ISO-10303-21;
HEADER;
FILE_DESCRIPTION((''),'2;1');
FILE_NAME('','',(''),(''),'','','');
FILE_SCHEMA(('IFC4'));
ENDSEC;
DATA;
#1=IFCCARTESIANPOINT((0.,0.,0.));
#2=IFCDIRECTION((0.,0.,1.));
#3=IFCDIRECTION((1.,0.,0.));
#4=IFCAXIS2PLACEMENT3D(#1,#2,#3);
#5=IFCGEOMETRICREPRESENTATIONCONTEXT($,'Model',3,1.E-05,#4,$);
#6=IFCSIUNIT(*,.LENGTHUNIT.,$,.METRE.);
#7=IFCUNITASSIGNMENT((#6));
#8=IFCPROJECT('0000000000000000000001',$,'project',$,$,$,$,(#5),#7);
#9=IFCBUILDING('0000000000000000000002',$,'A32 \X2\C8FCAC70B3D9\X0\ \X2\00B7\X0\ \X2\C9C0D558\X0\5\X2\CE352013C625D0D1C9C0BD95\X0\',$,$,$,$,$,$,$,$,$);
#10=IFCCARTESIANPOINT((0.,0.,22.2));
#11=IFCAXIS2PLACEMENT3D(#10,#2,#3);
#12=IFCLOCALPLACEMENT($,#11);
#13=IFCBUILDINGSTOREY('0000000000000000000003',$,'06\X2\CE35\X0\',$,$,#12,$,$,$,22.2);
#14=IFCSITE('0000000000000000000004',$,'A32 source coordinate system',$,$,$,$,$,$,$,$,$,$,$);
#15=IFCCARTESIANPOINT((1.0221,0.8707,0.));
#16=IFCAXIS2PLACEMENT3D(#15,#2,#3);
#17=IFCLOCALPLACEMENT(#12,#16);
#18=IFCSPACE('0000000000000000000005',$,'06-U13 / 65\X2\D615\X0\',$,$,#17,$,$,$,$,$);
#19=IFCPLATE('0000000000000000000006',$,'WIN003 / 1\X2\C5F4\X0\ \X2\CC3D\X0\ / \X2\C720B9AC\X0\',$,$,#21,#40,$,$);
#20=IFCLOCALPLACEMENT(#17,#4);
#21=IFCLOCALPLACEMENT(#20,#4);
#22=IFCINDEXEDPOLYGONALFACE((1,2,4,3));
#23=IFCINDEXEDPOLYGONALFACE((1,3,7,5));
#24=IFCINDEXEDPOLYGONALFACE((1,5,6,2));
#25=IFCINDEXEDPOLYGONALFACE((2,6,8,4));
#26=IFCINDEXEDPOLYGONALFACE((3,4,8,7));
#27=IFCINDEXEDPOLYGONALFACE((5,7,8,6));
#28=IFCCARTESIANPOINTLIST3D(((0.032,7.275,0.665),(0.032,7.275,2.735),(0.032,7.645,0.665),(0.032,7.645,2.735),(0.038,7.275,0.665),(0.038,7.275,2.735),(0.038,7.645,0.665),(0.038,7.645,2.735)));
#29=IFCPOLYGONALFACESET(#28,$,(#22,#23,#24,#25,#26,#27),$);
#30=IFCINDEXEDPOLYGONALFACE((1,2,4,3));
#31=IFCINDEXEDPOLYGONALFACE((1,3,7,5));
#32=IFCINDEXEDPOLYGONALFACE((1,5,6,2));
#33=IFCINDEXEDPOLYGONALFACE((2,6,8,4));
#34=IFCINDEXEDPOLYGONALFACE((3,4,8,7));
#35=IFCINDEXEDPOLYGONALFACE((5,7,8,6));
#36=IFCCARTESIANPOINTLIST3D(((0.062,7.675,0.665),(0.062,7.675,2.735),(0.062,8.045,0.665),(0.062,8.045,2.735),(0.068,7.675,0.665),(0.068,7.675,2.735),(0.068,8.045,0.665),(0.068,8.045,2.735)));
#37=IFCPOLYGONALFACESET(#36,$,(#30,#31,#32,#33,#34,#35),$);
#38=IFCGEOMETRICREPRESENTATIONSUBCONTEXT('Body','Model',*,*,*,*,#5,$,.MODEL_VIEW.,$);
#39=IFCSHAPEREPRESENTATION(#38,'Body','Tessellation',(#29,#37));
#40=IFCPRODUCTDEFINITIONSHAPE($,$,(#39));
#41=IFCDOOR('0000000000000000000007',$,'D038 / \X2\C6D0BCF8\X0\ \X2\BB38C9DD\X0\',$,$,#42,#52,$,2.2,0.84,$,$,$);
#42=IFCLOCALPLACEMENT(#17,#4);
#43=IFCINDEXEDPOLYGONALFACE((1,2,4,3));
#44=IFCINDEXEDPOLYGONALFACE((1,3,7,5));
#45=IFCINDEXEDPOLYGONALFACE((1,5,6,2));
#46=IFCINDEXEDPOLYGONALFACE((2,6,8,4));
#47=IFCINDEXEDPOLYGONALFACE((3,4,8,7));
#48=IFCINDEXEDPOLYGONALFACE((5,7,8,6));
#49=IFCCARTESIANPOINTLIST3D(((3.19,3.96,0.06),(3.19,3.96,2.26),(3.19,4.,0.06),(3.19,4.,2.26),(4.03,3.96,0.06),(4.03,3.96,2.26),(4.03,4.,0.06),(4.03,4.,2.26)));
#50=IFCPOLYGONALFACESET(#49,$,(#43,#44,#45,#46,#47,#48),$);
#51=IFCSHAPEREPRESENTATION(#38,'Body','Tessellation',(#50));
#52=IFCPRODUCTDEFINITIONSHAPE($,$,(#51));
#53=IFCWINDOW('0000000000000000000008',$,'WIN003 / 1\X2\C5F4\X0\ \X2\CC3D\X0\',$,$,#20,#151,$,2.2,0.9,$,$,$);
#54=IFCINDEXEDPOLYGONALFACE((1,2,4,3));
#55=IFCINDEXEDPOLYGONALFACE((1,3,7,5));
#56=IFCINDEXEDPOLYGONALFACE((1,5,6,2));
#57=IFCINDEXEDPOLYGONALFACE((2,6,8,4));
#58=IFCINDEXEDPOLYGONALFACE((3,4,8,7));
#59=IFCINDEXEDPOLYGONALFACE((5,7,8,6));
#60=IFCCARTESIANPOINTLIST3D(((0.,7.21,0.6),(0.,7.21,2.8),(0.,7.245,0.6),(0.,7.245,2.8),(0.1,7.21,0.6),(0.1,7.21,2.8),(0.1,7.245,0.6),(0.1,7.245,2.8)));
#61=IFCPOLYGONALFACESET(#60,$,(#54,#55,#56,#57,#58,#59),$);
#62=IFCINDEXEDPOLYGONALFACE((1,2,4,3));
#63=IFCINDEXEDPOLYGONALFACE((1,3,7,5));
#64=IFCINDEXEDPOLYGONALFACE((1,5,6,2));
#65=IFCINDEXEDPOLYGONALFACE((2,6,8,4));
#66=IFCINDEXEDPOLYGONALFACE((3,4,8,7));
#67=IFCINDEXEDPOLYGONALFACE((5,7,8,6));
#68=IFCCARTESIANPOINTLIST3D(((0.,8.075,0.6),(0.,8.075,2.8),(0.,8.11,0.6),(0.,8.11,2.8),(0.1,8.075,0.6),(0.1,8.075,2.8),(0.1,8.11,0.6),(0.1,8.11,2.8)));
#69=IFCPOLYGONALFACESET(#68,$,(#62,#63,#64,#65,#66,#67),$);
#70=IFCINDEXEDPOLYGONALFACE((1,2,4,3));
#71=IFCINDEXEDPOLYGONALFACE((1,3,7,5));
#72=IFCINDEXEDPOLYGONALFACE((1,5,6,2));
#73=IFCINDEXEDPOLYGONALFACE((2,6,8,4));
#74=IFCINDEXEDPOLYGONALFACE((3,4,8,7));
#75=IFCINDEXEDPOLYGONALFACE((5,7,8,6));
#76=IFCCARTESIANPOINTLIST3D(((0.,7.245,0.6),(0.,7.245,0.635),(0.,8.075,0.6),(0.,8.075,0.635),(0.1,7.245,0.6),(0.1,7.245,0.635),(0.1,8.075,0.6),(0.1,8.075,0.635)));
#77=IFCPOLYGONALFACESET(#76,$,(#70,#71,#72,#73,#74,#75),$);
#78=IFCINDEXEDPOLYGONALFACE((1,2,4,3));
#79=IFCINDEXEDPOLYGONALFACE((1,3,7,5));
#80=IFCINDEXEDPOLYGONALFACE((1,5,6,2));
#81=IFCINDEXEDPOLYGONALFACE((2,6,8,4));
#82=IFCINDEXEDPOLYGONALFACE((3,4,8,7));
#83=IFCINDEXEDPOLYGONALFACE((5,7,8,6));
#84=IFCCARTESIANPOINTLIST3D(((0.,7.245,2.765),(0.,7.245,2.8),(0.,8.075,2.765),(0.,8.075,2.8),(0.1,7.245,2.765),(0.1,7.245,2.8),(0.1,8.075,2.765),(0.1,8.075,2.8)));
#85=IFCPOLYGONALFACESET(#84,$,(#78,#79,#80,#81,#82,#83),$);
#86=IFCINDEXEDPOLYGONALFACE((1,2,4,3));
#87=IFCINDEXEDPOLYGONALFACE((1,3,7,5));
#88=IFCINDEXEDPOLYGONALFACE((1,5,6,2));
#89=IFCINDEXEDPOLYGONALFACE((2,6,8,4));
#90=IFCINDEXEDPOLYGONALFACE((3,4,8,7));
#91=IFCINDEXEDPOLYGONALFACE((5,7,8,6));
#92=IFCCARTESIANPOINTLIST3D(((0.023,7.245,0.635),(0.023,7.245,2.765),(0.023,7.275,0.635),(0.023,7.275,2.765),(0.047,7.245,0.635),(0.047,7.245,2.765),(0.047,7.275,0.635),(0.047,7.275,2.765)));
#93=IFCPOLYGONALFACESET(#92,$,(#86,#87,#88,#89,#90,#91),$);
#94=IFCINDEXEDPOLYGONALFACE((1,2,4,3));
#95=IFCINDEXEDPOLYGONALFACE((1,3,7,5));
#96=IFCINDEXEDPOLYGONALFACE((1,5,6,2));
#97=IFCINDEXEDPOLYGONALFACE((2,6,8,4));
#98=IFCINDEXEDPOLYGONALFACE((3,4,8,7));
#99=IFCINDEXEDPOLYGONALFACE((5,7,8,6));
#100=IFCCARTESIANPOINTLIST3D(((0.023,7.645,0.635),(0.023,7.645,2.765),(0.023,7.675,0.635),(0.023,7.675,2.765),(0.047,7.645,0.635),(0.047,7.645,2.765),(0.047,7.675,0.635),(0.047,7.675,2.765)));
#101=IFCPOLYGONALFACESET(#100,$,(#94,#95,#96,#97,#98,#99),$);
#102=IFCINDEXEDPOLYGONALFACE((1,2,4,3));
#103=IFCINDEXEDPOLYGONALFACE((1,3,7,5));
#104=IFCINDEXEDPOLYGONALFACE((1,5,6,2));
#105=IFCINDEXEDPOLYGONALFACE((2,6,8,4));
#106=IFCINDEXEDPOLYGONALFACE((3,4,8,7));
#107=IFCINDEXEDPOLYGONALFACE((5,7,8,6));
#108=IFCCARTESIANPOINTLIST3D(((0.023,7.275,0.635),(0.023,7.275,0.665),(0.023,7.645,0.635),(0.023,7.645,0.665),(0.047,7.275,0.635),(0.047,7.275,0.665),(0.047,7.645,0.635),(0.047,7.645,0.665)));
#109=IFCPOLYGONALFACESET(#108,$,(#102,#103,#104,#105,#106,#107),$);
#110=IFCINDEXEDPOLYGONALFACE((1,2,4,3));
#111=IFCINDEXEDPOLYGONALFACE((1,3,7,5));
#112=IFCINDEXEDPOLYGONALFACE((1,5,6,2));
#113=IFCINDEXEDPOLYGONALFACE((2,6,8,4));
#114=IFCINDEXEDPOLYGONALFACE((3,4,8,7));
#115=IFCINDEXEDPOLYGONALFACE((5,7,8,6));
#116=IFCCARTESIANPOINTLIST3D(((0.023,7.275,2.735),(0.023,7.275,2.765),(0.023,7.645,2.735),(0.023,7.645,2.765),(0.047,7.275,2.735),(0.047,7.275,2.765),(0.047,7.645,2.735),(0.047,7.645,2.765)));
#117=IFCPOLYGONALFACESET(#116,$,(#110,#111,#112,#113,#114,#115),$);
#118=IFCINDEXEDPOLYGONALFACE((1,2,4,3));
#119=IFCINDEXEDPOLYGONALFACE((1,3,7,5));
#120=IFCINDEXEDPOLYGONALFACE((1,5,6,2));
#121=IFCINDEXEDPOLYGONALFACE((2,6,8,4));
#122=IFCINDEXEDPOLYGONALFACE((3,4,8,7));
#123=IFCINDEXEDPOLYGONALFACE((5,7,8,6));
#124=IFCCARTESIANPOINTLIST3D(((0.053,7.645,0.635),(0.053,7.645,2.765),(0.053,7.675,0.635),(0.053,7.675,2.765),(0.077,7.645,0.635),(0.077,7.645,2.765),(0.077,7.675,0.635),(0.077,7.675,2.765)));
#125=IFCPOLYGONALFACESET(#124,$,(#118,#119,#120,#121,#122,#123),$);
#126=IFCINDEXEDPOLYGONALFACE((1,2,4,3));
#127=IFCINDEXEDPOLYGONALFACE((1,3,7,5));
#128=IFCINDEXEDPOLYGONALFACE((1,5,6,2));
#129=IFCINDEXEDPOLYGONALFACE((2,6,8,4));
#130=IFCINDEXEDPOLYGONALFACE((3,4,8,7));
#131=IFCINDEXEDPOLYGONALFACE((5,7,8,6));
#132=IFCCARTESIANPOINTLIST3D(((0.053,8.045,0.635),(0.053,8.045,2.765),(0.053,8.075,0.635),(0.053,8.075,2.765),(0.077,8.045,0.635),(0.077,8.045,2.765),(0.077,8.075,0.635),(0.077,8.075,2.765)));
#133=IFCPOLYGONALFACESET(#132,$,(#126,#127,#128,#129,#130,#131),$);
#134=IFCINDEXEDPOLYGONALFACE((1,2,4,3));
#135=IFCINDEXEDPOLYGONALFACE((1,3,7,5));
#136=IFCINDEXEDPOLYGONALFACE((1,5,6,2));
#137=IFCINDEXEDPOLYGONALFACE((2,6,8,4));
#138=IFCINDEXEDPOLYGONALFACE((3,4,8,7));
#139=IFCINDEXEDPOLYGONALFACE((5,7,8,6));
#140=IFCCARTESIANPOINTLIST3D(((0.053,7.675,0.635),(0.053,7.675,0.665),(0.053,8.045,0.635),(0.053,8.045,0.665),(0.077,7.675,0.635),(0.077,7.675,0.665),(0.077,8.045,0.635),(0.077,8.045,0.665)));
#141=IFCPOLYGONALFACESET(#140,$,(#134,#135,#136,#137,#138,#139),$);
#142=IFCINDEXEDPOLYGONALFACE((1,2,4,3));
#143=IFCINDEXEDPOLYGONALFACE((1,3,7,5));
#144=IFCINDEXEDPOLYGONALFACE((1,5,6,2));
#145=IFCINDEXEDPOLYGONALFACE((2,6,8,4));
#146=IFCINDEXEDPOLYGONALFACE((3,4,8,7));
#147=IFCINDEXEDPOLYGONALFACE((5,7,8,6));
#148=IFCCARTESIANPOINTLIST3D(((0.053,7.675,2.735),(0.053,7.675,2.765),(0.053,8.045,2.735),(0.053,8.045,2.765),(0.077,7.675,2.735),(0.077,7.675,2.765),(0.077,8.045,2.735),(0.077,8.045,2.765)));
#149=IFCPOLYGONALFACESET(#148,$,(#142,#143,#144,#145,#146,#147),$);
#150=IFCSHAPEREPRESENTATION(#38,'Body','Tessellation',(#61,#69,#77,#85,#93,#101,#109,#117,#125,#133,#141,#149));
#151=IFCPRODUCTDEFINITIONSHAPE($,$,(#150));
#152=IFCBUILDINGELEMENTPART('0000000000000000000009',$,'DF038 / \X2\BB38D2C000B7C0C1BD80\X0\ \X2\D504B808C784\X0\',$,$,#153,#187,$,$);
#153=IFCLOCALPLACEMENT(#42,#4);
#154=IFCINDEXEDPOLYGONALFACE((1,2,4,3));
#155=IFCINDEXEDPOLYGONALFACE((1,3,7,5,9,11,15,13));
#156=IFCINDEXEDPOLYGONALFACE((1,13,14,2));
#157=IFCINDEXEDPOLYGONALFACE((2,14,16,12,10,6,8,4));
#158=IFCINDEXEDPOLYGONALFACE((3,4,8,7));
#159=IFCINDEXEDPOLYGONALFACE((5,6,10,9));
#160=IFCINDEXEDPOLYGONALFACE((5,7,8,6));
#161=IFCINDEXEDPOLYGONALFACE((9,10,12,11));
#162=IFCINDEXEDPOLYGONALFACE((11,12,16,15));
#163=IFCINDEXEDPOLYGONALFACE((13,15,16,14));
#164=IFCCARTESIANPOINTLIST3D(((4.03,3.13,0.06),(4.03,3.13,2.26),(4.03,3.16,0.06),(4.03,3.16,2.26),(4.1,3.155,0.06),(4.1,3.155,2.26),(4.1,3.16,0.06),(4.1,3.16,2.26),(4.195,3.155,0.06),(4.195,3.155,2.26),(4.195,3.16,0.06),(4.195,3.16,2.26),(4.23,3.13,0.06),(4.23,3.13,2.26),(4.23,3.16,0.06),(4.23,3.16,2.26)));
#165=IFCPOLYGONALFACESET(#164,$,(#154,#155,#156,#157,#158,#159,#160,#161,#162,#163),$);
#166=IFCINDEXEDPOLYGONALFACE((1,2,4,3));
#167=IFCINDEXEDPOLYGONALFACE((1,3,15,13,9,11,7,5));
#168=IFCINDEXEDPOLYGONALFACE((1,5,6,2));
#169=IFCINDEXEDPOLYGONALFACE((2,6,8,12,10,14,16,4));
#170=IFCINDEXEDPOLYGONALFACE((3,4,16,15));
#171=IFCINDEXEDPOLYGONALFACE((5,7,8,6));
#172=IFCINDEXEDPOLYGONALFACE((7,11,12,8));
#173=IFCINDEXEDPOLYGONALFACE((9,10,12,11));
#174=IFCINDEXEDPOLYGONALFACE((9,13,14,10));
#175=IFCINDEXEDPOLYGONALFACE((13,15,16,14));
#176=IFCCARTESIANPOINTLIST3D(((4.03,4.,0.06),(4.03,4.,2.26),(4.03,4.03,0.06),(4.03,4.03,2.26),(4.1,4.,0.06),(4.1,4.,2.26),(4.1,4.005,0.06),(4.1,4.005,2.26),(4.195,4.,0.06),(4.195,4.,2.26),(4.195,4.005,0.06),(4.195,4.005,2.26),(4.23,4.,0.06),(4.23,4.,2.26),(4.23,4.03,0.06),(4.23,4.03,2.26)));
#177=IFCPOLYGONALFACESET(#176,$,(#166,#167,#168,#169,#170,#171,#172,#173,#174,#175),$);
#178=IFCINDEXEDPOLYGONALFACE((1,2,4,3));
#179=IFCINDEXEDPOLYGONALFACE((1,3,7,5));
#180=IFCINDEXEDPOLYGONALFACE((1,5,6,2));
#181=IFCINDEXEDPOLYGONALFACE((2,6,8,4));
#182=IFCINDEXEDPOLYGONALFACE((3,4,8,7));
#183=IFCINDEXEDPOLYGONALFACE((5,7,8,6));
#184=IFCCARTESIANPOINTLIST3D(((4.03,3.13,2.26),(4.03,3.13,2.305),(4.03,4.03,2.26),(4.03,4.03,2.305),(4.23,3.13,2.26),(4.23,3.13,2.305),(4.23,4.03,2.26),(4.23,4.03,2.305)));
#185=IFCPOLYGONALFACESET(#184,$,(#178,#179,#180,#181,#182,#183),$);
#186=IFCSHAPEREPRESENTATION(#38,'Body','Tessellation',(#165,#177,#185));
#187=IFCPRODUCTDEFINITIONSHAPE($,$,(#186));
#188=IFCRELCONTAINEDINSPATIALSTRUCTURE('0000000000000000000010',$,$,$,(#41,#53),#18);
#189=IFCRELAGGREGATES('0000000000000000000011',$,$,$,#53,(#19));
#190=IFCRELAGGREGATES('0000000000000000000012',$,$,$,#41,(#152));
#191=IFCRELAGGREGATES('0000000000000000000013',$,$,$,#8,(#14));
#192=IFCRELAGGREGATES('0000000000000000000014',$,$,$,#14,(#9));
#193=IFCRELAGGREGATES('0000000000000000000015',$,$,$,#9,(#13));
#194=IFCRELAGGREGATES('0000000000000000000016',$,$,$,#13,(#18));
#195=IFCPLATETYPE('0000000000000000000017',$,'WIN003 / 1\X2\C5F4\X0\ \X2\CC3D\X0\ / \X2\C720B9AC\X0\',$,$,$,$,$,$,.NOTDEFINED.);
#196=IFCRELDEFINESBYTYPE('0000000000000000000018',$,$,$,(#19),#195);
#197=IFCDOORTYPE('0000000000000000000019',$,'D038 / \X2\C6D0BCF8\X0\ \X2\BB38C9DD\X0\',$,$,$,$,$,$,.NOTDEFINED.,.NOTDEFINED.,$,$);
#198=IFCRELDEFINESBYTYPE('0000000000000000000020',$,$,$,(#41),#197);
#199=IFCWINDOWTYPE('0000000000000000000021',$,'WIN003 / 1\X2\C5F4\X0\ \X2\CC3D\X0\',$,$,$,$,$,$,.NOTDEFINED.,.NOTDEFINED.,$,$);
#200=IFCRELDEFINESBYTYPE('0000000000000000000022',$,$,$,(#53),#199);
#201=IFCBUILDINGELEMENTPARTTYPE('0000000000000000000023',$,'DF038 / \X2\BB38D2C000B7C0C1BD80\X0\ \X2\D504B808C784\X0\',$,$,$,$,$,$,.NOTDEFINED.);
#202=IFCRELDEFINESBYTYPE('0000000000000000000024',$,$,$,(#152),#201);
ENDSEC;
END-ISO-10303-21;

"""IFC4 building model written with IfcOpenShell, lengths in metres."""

from ifc_helpers import new_model, si_unit, frame, origin, origin_with_axes, place, context, subcontext, project, spatial, polyline, outline, extrude, source, transform, mapped, type_object, type_shapes, element, aggregate, save


model = new_model("IFC4")

# Units and contexts
model_context = context("Model", 3, precision=1e-05, world=origin_with_axes())
body_context = subcontext(model_context, "Body", "Model", "MODEL_VIEW")
ifc_project = project(units=[si_unit("LENGTHUNIT", "METRE")], contexts=[model_context])

# Plate
storey_placement = place(None, frame((0.0, 0.0, 22.2), z_axis=(0.0, 0.0, 1.0), x_axis=(1.0, 0.0, 0.0)))
space_placement = place(storey_placement, frame((1.0221, 0.8707, 0.0), z_axis=(0.0, 0.0, 1.0), x_axis=(1.0, 0.0, 0.0)))
plate_type_1 = type_object("IfcPlateType", Name="WIN003 / 1열 창 / 유리", PredefinedType="NOTDEFINED")
shared_shape_1 = source(origin(), body_context, "Body", "SweptSolid", [
    extrude(outline(polyline([(0.032, 7.275), (0.032, 7.645), (0.038, 7.645), (0.038, 7.275), (0.032, 7.275)])), frame((0.0, 0.0, 0.665)), (0.0, 0.0, 1.0), 2.07),
    extrude(outline(polyline([(0.062, 7.675), (0.062, 8.045), (0.068, 8.045), (0.068, 7.675), (0.062, 7.675)])), frame((0.0, 0.0, 0.665)), (0.0, 0.0, 1.0), 2.07),
])
type_shapes(plate_type_1, [shared_shape_1])
window_1_placement = place(space_placement, origin_with_axes())
plate_1_placement = place(window_1_placement, origin_with_axes())
plate_1 = element("IfcPlate", 1, at=plate_1_placement, type_object=plate_type_1, Name="WIN003 / 1열 창 / 유리", context=body_context, shape_type="MappedRepresentation", body=[
    mapped(shared_shape_1, transform((0.0, 0.0, 0.0), scale=1.0)),
])

# Site, building, storey, space
site = spatial("IfcSite", under=ifc_project, Name="A32 source coordinate system")
building = spatial("IfcBuilding", under=site, Name="A32 주거동 · 지하5층–옥탑지붕")
storey = spatial("IfcBuildingStorey", under=building, at=storey_placement, Name="06층", Elevation=22.2)
space = spatial("IfcSpace", under=storey, at=space_placement, Name="06-U13 / 65형")

# Door
door_type_1 = type_object("IfcDoorType", Name="D038 / 원본 문짝", OperationType="NOTDEFINED", PredefinedType="NOTDEFINED")
shared_shape_2 = source(origin(), body_context, "Body", "SweptSolid", [
    extrude(outline(polyline([(3.19, 3.96), (3.19, 4.0), (4.03, 4.0), (4.03, 3.96), (3.19, 3.96)])), frame((0.0, 0.0, 0.06)), (0.0, 0.0, 1.0), 2.2),
])
type_shapes(door_type_1, [shared_shape_2])
door_1_placement = place(space_placement, origin_with_axes())
door_1 = element("IfcDoor", 2, at=door_1_placement, inside=space, type_object=door_type_1, Name="D038 / 원본 문짝", OverallHeight=2.2, OverallWidth=0.84, context=body_context, shape_type="MappedRepresentation", body=[
    mapped(shared_shape_2, transform((0.0, 0.0, 0.0), scale=1.0)),
])

# Window
window_type_1 = type_object("IfcWindowType", Name="WIN003 / 1열 창", PartitioningType="NOTDEFINED", PredefinedType="NOTDEFINED")
shared_shape_3 = source(origin(), body_context, "Body", "SweptSolid", [
    extrude(outline(polyline([(0.0, 7.21), (0.0, 7.245), (0.1, 7.245), (0.1, 7.21), (0.0, 7.21)])), frame((0.0, 0.0, 0.6)), (0.0, 0.0, 1.0), 2.2),
    extrude(outline(polyline([(0.0, 8.075), (0.0, 8.11), (0.1, 8.11), (0.1, 8.075), (0.0, 8.075)])), frame((0.0, 0.0, 0.6)), (0.0, 0.0, 1.0), 2.2),
    extrude(outline(polyline([(0.0, 7.245), (0.0, 8.075), (0.1, 8.075), (0.1, 7.245), (0.0, 7.245)])), frame((0.0, 0.0, 0.6)), (0.0, 0.0, 1.0), 0.035),
    extrude(outline(polyline([(0.0, 7.245), (0.0, 8.075), (0.1, 8.075), (0.1, 7.245), (0.0, 7.245)])), frame((0.0, 0.0, 2.765)), (0.0, 0.0, 1.0), 0.035),
    extrude(outline(polyline([(0.023, 7.245), (0.023, 7.275), (0.047, 7.275), (0.047, 7.245), (0.023, 7.245)])), frame((0.0, 0.0, 0.635)), (0.0, 0.0, 1.0), 2.13),
    extrude(outline(polyline([(0.023, 7.645), (0.023, 7.675), (0.047, 7.675), (0.047, 7.645), (0.023, 7.645)])), frame((0.0, 0.0, 0.635)), (0.0, 0.0, 1.0), 2.13),
    extrude(outline(polyline([(0.023, 7.275), (0.023, 7.645), (0.047, 7.645), (0.047, 7.275), (0.023, 7.275)])), frame((0.0, 0.0, 0.635)), (0.0, 0.0, 1.0), 0.03),
    extrude(outline(polyline([(0.023, 7.275), (0.023, 7.645), (0.047, 7.645), (0.047, 7.275), (0.023, 7.275)])), frame((0.0, 0.0, 2.735)), (0.0, 0.0, 1.0), 0.03),
    extrude(outline(polyline([(0.053, 7.645), (0.053, 7.675), (0.077, 7.675), (0.077, 7.645), (0.053, 7.645)])), frame((0.0, 0.0, 0.635)), (0.0, 0.0, 1.0), 2.13),
    extrude(outline(polyline([(0.053, 8.045), (0.053, 8.075), (0.077, 8.075), (0.077, 8.045), (0.053, 8.045)])), frame((0.0, 0.0, 0.635)), (0.0, 0.0, 1.0), 2.13),
    extrude(outline(polyline([(0.053, 7.675), (0.053, 8.045), (0.077, 8.045), (0.077, 7.675), (0.053, 7.675)])), frame((0.0, 0.0, 0.635)), (0.0, 0.0, 1.0), 0.03),
    extrude(outline(polyline([(0.053, 7.675), (0.053, 8.045), (0.077, 8.045), (0.077, 7.675), (0.053, 7.675)])), frame((0.0, 0.0, 2.735)), (0.0, 0.0, 1.0), 0.03),
])
type_shapes(window_type_1, [shared_shape_3])
window_1 = element("IfcWindow", 3, at=window_1_placement, inside=space, type_object=window_type_1, Name="WIN003 / 1열 창", OverallHeight=2.2, OverallWidth=0.9, context=body_context, shape_type="MappedRepresentation", body=[
    mapped(shared_shape_3, transform((0.0, 0.0, 0.0), scale=1.0)),
])
aggregate(window_1, [plate_1])

# Building element part
building_element_part_type_1 = type_object("IfcBuildingElementPartType", Name="DF038 / 문틀·상부 프레임", PredefinedType="NOTDEFINED")
shared_shape_4 = source(origin(), body_context, "Body", "SweptSolid", [
    extrude(outline(polyline([(4.03, 3.16), (4.1, 3.16), (4.1, 3.155), (4.195, 3.155), (4.195, 3.16), (4.23, 3.16), (4.23, 3.13), (4.03, 3.13), (4.03, 3.16)])), frame((0.0, 0.0, 0.06)), (0.0, 0.0, 1.0), 2.2),
    extrude(outline(polyline([(4.23, 4.03), (4.23, 4.0), (4.195, 4.0), (4.195, 4.005), (4.1, 4.005), (4.1, 4.0), (4.03, 4.0), (4.03, 4.03), (4.23, 4.03)])), frame((0.0, 0.0, 0.06)), (0.0, 0.0, 1.0), 2.2),
    extrude(outline(polyline([(4.03, 3.13), (4.03, 4.03), (4.23, 4.03), (4.23, 3.13), (4.03, 3.13)])), frame((0.0, 0.0, 2.26)), (0.0, 0.0, 1.0), 0.045),
])
type_shapes(building_element_part_type_1, [shared_shape_4])
building_element_part_1_placement = place(door_1_placement, origin_with_axes())
building_element_part_1 = element("IfcBuildingElementPart", 4, at=building_element_part_1_placement, type_object=building_element_part_type_1, Name="DF038 / 문틀·상부 프레임", context=body_context, shape_type="MappedRepresentation", body=[
    mapped(shared_shape_4, transform((0.0, 0.0, 0.0), scale=1.0)),
])
aggregate(door_1, [building_element_part_1])

save(model, "model.ifc")
